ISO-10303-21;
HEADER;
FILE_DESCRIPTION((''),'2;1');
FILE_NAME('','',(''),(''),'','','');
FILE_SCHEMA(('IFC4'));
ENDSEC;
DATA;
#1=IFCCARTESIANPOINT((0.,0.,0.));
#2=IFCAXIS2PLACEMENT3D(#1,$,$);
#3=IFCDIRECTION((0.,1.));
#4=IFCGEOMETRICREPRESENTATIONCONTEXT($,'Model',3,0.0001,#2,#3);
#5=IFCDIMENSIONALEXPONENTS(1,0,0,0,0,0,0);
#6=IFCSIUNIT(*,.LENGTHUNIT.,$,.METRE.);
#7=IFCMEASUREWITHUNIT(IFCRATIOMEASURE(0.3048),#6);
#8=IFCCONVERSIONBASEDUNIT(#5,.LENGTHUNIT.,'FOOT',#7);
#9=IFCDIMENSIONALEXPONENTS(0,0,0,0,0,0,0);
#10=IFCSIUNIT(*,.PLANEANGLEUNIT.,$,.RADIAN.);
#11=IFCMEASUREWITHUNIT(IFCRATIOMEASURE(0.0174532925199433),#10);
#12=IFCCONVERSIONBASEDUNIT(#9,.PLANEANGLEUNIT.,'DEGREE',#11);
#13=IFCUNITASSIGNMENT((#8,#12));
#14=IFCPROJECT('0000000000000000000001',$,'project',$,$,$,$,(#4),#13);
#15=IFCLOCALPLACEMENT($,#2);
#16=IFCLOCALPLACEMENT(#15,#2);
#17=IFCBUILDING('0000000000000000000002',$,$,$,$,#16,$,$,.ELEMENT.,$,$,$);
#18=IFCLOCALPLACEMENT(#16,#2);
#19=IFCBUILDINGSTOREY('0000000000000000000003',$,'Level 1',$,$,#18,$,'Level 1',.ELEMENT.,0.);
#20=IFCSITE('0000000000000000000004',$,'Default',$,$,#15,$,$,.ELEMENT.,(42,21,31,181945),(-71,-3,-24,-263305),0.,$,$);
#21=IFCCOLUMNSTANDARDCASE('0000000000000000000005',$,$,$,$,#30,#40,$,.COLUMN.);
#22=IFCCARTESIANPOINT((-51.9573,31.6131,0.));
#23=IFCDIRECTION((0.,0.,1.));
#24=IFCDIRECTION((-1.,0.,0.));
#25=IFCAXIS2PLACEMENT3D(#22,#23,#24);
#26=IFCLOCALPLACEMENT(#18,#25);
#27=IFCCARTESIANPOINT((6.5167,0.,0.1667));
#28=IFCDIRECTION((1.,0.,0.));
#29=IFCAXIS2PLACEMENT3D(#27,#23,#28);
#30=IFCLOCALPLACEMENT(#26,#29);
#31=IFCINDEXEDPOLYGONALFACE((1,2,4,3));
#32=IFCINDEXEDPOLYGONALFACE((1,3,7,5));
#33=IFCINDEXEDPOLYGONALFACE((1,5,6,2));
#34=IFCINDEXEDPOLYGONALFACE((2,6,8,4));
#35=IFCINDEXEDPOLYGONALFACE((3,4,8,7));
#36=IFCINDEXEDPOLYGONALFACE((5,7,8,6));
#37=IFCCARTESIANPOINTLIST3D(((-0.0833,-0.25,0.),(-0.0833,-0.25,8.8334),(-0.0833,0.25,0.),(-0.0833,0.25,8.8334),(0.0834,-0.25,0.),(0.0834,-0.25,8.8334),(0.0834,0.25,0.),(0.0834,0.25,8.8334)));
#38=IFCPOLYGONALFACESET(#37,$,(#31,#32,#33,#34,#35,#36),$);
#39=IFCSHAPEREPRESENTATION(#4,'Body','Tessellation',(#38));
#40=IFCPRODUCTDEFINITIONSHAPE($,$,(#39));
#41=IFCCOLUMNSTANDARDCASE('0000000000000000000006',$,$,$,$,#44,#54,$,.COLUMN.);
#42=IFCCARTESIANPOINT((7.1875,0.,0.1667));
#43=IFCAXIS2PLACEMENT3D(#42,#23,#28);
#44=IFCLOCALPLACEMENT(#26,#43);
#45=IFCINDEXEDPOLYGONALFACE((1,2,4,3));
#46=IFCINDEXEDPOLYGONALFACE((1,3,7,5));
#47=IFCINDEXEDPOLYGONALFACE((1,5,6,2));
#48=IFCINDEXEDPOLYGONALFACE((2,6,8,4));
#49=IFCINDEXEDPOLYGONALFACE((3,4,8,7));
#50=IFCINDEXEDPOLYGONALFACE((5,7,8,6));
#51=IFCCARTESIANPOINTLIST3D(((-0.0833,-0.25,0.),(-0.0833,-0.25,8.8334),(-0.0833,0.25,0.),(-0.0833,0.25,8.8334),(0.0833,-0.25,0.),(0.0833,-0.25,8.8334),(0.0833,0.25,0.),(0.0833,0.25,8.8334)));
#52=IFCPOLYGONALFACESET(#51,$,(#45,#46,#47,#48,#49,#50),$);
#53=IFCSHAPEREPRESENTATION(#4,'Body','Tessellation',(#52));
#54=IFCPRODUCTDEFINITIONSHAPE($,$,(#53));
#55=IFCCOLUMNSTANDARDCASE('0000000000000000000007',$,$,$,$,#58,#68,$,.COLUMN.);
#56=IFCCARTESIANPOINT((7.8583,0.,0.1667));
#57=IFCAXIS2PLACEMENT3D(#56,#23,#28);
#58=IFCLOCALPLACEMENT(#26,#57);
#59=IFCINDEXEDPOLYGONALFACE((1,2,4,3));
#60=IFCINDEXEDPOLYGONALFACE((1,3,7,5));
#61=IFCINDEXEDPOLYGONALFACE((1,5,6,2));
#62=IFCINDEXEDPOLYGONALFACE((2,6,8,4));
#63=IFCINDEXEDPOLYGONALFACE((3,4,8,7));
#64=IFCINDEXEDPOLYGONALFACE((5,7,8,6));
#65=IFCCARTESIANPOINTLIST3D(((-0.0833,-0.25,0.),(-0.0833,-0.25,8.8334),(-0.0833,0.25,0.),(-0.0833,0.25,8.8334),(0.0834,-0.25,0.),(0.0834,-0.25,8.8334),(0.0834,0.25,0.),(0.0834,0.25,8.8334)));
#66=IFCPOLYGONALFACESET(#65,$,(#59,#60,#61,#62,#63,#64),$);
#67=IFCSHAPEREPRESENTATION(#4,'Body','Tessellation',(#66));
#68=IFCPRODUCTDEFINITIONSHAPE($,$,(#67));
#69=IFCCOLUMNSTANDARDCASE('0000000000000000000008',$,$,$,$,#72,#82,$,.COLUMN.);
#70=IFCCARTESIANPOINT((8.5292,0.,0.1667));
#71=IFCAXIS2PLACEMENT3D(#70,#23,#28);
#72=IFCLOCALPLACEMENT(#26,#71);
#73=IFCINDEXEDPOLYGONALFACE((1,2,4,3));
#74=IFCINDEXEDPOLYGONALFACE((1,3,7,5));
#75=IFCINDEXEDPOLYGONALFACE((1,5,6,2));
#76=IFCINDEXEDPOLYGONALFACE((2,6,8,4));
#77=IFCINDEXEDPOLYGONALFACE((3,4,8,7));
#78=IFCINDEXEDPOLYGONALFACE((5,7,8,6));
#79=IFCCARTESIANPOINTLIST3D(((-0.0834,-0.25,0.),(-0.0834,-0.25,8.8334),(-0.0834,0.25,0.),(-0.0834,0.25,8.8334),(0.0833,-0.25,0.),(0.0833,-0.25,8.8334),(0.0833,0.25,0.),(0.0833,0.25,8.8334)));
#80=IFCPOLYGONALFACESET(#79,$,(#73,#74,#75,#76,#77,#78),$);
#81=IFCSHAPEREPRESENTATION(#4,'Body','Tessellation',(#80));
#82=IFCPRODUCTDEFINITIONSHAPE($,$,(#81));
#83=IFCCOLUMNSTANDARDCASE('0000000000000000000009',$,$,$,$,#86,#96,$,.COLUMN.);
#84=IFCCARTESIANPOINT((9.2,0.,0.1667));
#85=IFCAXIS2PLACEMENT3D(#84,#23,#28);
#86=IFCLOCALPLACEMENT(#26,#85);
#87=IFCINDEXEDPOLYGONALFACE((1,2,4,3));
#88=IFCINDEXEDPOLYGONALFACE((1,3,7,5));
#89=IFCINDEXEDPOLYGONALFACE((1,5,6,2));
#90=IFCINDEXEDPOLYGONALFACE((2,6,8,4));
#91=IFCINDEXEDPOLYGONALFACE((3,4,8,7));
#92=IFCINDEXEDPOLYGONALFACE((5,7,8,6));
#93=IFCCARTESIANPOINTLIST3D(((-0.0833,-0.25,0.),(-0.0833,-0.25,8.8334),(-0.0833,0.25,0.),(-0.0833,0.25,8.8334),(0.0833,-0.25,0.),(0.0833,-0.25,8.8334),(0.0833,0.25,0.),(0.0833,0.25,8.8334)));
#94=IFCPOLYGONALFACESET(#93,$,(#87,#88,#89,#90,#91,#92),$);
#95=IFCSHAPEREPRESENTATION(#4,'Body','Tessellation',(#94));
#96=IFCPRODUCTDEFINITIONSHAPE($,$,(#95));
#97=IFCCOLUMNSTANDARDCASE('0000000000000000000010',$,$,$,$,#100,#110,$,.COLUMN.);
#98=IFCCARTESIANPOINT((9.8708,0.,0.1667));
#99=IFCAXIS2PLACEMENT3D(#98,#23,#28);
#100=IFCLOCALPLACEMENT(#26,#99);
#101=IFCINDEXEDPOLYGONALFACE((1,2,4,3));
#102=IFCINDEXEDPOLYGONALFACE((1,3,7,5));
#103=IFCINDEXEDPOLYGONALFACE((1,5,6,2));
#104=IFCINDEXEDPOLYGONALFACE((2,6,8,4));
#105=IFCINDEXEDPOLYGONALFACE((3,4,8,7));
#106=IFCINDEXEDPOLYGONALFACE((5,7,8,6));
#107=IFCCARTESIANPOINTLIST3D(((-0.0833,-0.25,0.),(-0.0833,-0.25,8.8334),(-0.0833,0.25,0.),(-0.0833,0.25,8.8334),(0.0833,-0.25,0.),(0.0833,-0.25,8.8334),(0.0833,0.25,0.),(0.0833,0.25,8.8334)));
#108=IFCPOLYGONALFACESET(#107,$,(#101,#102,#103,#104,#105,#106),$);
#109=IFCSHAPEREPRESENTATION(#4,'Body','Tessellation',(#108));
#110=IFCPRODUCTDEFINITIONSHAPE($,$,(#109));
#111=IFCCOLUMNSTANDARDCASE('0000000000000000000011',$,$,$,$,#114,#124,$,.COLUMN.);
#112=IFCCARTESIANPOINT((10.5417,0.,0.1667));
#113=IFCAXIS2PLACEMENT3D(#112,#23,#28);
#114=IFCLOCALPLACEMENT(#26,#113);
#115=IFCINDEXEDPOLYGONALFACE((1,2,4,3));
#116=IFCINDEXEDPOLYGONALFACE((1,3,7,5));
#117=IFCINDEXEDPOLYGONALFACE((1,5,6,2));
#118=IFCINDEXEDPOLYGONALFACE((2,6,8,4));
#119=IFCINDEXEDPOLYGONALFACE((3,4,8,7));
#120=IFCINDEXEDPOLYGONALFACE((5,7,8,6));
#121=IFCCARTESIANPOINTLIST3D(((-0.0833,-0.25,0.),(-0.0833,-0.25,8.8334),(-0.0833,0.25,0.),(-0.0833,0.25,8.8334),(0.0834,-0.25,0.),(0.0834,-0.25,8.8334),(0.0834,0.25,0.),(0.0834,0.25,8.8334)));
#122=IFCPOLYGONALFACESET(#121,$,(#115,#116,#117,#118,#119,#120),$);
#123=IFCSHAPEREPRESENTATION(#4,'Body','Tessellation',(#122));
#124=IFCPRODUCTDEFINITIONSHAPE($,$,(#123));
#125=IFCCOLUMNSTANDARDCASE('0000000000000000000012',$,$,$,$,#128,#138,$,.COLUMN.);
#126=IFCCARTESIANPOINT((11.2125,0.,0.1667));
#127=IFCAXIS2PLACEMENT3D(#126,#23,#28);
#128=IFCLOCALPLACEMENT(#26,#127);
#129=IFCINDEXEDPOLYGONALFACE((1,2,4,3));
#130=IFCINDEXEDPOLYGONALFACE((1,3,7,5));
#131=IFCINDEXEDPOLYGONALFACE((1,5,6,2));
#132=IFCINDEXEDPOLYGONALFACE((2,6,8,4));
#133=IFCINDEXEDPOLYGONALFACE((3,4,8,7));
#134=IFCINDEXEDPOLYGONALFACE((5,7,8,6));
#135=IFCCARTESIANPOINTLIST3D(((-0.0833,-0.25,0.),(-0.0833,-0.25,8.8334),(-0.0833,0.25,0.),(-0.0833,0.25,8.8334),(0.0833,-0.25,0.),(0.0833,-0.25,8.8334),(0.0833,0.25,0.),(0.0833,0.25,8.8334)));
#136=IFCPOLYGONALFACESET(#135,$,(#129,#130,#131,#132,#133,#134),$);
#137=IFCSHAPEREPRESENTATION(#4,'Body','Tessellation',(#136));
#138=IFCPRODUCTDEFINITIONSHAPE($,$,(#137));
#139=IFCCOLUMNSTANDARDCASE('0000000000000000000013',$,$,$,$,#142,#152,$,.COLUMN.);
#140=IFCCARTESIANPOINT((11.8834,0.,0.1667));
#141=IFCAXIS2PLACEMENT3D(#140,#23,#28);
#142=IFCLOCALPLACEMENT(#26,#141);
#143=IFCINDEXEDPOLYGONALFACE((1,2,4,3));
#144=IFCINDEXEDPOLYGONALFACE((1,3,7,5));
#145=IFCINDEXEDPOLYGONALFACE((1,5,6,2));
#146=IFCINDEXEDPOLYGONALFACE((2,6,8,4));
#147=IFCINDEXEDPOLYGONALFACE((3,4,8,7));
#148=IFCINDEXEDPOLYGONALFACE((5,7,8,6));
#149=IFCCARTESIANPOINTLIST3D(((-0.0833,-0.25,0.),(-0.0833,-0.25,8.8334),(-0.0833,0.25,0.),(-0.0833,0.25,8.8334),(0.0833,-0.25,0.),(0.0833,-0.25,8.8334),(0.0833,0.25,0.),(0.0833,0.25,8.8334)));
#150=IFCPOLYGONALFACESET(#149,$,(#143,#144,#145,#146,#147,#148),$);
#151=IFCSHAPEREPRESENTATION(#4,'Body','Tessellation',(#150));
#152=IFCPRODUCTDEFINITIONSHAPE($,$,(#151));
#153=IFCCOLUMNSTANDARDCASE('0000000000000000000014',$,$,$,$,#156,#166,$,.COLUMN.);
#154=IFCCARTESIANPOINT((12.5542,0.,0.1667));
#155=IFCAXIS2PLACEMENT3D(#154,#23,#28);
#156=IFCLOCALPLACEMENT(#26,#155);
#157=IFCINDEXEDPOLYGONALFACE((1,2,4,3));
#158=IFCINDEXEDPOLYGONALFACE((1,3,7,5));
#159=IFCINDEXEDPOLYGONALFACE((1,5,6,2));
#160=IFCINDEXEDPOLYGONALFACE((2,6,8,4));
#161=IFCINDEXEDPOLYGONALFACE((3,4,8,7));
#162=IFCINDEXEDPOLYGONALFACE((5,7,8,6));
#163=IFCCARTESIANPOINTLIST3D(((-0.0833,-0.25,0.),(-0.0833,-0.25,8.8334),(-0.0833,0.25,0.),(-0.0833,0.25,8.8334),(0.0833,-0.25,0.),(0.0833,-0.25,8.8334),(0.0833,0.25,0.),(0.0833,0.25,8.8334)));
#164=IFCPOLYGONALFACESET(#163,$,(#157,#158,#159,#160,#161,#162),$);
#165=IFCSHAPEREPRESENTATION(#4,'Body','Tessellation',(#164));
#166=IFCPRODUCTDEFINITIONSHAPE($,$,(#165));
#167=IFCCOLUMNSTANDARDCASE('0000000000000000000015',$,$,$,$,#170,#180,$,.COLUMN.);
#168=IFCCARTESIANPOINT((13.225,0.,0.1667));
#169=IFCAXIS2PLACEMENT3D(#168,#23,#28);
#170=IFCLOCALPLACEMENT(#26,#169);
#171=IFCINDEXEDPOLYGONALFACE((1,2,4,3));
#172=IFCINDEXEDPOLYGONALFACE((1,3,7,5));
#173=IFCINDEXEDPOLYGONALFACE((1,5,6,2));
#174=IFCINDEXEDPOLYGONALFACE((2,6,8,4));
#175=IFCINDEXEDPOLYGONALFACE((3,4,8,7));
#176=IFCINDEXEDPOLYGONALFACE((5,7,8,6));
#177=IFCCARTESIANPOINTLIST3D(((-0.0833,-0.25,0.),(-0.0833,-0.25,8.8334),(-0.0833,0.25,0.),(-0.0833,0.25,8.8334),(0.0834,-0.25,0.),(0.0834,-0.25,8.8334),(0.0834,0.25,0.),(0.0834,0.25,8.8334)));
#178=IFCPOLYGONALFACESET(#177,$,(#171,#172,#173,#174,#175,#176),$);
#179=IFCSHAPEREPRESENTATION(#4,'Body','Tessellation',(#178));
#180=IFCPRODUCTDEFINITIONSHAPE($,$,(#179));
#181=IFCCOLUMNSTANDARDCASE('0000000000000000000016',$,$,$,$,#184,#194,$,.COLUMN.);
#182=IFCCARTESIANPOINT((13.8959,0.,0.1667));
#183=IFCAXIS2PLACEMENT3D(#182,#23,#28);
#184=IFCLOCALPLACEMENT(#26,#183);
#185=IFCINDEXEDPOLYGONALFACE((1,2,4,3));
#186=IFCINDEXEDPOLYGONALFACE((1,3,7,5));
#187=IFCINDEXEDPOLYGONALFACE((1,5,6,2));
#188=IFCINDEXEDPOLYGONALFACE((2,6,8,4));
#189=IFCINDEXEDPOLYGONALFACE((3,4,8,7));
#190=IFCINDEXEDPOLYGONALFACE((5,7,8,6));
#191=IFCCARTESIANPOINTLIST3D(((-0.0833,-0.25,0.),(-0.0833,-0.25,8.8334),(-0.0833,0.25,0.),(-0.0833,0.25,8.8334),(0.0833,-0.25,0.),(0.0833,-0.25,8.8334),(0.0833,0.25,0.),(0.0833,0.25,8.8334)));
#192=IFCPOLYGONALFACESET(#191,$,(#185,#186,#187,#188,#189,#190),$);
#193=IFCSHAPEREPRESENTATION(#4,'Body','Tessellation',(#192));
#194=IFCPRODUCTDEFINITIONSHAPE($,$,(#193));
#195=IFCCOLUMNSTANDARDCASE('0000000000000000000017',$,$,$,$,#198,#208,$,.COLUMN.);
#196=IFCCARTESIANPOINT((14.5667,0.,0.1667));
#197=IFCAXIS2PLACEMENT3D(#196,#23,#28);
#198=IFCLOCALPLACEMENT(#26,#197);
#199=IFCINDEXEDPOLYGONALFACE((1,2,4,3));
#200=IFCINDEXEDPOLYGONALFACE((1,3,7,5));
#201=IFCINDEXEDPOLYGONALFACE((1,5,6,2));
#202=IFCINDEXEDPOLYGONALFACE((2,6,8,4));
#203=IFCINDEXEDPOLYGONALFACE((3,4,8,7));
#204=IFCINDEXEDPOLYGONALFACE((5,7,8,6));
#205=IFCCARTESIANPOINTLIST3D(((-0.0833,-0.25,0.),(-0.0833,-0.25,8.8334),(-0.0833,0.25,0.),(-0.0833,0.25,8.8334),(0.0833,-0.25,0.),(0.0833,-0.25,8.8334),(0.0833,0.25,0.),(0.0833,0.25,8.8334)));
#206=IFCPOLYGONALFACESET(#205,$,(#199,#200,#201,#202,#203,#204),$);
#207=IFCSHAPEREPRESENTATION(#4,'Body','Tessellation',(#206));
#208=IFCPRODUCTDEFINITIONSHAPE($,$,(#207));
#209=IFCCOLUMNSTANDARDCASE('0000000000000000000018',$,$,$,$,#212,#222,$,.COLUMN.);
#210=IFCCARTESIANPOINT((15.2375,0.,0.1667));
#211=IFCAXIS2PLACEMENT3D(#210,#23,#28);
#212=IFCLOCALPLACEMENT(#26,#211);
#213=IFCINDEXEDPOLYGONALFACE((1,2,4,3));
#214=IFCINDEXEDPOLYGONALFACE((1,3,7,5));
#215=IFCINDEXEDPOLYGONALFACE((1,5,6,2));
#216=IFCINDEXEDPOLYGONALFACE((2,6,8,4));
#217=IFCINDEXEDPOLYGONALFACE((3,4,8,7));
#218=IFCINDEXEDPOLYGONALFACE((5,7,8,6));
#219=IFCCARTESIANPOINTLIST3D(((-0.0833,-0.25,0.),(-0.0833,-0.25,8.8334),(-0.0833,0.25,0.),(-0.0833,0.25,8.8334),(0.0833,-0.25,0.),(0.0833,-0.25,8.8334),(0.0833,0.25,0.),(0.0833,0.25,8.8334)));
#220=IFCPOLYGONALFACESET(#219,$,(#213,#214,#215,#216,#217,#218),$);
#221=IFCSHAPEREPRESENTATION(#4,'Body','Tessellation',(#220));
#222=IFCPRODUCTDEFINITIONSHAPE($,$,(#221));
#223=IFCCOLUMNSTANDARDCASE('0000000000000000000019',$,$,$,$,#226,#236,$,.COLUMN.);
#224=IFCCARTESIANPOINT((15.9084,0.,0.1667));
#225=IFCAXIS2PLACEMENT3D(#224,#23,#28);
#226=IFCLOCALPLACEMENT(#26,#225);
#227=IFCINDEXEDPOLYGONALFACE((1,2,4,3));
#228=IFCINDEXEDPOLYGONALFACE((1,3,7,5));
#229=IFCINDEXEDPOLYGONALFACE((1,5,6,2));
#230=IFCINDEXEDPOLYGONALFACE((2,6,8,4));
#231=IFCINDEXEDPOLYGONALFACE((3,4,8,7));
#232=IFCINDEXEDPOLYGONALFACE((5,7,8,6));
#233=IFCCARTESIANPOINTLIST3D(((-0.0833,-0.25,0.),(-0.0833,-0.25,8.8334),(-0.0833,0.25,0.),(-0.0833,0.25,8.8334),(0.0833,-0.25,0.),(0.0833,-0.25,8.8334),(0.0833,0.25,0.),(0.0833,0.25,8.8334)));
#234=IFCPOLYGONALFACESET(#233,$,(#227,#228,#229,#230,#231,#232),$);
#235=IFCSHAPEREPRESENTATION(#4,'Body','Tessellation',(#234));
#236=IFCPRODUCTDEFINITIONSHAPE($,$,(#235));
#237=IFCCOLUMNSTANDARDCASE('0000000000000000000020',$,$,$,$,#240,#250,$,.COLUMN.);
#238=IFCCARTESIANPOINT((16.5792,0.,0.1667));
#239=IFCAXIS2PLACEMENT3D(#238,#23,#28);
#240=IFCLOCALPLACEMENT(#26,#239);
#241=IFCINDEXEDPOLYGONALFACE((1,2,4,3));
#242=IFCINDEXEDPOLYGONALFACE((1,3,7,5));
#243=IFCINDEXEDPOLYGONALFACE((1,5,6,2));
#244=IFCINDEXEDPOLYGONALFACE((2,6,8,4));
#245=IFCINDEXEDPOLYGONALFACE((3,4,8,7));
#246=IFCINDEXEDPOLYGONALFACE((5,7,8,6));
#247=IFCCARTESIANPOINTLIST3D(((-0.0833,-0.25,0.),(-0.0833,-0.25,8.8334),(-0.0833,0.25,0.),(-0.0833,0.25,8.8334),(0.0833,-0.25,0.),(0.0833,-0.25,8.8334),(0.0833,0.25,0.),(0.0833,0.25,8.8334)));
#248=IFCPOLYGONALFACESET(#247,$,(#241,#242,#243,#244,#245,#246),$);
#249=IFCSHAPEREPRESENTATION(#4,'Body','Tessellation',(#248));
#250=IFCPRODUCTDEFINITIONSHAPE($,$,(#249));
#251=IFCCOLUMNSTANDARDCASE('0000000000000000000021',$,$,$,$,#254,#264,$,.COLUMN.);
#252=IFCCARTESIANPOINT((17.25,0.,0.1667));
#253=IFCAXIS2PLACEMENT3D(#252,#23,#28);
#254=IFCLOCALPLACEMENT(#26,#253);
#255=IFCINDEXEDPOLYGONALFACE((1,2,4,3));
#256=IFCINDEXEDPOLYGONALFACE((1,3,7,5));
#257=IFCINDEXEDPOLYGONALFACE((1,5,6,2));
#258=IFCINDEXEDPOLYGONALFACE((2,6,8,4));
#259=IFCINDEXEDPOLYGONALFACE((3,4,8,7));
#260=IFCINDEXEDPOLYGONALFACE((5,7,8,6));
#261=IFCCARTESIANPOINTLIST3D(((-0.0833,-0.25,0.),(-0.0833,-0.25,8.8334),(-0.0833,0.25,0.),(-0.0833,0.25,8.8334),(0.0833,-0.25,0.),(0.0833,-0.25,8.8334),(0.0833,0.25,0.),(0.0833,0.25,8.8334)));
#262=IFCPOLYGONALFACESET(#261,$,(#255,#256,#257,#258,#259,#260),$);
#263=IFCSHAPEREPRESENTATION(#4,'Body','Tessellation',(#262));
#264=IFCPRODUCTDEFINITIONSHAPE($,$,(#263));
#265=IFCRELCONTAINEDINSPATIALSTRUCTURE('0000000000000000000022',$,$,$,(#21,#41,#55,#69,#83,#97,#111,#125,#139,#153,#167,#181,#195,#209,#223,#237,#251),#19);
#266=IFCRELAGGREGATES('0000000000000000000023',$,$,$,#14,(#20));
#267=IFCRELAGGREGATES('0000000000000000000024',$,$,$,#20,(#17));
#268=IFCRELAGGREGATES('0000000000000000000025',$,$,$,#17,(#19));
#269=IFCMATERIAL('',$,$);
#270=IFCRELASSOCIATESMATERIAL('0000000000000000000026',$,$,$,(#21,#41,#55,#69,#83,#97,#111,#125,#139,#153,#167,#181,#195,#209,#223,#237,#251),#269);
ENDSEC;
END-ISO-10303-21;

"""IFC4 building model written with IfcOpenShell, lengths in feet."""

from ifc_helpers import new_model, entity, si_unit, converted_unit, direction, frame, origin, place, context, project, spatial, rectangle, extrude, material, element, save


model = new_model("IFC4")

# Units and contexts
model_context = context("Model", 3, precision=0.0001, world=origin(), true_north=direction((0.0, 1.0)))
ifc_project = project(units=[converted_unit("LENGTHUNIT", "FOOT", entity("IfcRatioMeasure", 0.3048), si_unit("LENGTHUNIT", "METRE"), dimensions=[1, 0, 0, 0, 0, 0, 0]), converted_unit("PLANEANGLEUNIT", "DEGREE", entity("IfcRatioMeasure", 0.0174532925199433), si_unit("PLANEANGLEUNIT", "RADIAN"), dimensions=[0, 0, 0, 0, 0, 0, 0])], contexts=[model_context])

# Site, building, storey
site_placement = place(None, origin())
site = spatial("IfcSite", under=ifc_project, at=site_placement, Name="Default", CompositionType="ELEMENT", RefLatitude=(42, 21, 31, 181945), RefLongitude=(-71, -3, -24, -263305), RefElevation=0.0)
building_placement = place(site_placement, origin())
building = spatial("IfcBuilding", under=site, at=building_placement, CompositionType="ELEMENT")
storey_placement = place(building_placement, origin())
storey = spatial("IfcBuildingStorey", under=building, at=storey_placement, Name="Level 1", LongName="Level 1", CompositionType="ELEMENT", Elevation=0.0)

# Columns
ifc_material_1 = material(Name="")
placement_1 = place(storey_placement, frame((-51.9573, 31.6131, 0.0), z_axis=(0.0, 0.0, 1.0), x_axis=(-1.0, 0.0, 0.0)))
for number, where, z_axis, x_axis in (
    (1, (6.5167, 0.0, 0.1667), (0.0, 0.0, 1.0), (1.0, 0.0, 0.0)),
    (2, (7.1875, 0.0, 0.1667), (0.0, 0.0, 1.0), (1.0, 0.0, 0.0)),
    (3, (7.8583, 0.0, 0.1667), (0.0, 0.0, 1.0), (1.0, 0.0, 0.0)),
    (4, (8.5292, 0.0, 0.1667), (0.0, 0.0, 1.0), (1.0, 0.0, 0.0)),
    (5, (9.2, 0.0, 0.1667), (0.0, 0.0, 1.0), (1.0, 0.0, 0.0)),
    (6, (9.8708, 0.0, 0.1667), (0.0, 0.0, 1.0), (1.0, 0.0, 0.0)),
    (7, (10.5417, 0.0, 0.1667), (0.0, 0.0, 1.0), (1.0, 0.0, 0.0)),
    (8, (11.2125, 0.0, 0.1667), (0.0, 0.0, 1.0), (1.0, 0.0, 0.0)),
    (9, (11.8834, 0.0, 0.1667), (0.0, 0.0, 1.0), (1.0, 0.0, 0.0)),
    (10, (12.5542, 0.0, 0.1667), (0.0, 0.0, 1.0), (1.0, 0.0, 0.0)),
    (11, (13.225, 0.0, 0.1667), (0.0, 0.0, 1.0), (1.0, 0.0, 0.0)),
    (12, (13.8959, 0.0, 0.1667), (0.0, 0.0, 1.0), (1.0, 0.0, 0.0)),
    (13, (14.5667, 0.0, 0.1667), (0.0, 0.0, 1.0), (1.0, 0.0, 0.0)),
    (14, (15.2375, 0.0, 0.1667), (0.0, 0.0, 1.0), (1.0, 0.0, 0.0)),
    (15, (15.9084, 0.0, 0.1667), (0.0, 0.0, 1.0), (1.0, 0.0, 0.0)),
    (16, (16.5792, 0.0, 0.1667), (0.0, 0.0, 1.0), (1.0, 0.0, 0.0)),
    (17, (17.25, 0.0, 0.1667), (0.0, 0.0, 1.0), (1.0, 0.0, 0.0)),
):
    element("IfcColumnStandardCase", number, at=place(placement_1, frame(where, z_axis=z_axis, x_axis=x_axis)), inside=storey, material=ifc_material_1, PredefinedType="COLUMN", context=model_context, shape_type="SweptSolid", body=[
        extrude(rectangle(XDim=0.1667, YDim=0.5), origin(), (0.0, 0.0, 1.0), 8.8334),
    ])

save(model, "model.ifc")
